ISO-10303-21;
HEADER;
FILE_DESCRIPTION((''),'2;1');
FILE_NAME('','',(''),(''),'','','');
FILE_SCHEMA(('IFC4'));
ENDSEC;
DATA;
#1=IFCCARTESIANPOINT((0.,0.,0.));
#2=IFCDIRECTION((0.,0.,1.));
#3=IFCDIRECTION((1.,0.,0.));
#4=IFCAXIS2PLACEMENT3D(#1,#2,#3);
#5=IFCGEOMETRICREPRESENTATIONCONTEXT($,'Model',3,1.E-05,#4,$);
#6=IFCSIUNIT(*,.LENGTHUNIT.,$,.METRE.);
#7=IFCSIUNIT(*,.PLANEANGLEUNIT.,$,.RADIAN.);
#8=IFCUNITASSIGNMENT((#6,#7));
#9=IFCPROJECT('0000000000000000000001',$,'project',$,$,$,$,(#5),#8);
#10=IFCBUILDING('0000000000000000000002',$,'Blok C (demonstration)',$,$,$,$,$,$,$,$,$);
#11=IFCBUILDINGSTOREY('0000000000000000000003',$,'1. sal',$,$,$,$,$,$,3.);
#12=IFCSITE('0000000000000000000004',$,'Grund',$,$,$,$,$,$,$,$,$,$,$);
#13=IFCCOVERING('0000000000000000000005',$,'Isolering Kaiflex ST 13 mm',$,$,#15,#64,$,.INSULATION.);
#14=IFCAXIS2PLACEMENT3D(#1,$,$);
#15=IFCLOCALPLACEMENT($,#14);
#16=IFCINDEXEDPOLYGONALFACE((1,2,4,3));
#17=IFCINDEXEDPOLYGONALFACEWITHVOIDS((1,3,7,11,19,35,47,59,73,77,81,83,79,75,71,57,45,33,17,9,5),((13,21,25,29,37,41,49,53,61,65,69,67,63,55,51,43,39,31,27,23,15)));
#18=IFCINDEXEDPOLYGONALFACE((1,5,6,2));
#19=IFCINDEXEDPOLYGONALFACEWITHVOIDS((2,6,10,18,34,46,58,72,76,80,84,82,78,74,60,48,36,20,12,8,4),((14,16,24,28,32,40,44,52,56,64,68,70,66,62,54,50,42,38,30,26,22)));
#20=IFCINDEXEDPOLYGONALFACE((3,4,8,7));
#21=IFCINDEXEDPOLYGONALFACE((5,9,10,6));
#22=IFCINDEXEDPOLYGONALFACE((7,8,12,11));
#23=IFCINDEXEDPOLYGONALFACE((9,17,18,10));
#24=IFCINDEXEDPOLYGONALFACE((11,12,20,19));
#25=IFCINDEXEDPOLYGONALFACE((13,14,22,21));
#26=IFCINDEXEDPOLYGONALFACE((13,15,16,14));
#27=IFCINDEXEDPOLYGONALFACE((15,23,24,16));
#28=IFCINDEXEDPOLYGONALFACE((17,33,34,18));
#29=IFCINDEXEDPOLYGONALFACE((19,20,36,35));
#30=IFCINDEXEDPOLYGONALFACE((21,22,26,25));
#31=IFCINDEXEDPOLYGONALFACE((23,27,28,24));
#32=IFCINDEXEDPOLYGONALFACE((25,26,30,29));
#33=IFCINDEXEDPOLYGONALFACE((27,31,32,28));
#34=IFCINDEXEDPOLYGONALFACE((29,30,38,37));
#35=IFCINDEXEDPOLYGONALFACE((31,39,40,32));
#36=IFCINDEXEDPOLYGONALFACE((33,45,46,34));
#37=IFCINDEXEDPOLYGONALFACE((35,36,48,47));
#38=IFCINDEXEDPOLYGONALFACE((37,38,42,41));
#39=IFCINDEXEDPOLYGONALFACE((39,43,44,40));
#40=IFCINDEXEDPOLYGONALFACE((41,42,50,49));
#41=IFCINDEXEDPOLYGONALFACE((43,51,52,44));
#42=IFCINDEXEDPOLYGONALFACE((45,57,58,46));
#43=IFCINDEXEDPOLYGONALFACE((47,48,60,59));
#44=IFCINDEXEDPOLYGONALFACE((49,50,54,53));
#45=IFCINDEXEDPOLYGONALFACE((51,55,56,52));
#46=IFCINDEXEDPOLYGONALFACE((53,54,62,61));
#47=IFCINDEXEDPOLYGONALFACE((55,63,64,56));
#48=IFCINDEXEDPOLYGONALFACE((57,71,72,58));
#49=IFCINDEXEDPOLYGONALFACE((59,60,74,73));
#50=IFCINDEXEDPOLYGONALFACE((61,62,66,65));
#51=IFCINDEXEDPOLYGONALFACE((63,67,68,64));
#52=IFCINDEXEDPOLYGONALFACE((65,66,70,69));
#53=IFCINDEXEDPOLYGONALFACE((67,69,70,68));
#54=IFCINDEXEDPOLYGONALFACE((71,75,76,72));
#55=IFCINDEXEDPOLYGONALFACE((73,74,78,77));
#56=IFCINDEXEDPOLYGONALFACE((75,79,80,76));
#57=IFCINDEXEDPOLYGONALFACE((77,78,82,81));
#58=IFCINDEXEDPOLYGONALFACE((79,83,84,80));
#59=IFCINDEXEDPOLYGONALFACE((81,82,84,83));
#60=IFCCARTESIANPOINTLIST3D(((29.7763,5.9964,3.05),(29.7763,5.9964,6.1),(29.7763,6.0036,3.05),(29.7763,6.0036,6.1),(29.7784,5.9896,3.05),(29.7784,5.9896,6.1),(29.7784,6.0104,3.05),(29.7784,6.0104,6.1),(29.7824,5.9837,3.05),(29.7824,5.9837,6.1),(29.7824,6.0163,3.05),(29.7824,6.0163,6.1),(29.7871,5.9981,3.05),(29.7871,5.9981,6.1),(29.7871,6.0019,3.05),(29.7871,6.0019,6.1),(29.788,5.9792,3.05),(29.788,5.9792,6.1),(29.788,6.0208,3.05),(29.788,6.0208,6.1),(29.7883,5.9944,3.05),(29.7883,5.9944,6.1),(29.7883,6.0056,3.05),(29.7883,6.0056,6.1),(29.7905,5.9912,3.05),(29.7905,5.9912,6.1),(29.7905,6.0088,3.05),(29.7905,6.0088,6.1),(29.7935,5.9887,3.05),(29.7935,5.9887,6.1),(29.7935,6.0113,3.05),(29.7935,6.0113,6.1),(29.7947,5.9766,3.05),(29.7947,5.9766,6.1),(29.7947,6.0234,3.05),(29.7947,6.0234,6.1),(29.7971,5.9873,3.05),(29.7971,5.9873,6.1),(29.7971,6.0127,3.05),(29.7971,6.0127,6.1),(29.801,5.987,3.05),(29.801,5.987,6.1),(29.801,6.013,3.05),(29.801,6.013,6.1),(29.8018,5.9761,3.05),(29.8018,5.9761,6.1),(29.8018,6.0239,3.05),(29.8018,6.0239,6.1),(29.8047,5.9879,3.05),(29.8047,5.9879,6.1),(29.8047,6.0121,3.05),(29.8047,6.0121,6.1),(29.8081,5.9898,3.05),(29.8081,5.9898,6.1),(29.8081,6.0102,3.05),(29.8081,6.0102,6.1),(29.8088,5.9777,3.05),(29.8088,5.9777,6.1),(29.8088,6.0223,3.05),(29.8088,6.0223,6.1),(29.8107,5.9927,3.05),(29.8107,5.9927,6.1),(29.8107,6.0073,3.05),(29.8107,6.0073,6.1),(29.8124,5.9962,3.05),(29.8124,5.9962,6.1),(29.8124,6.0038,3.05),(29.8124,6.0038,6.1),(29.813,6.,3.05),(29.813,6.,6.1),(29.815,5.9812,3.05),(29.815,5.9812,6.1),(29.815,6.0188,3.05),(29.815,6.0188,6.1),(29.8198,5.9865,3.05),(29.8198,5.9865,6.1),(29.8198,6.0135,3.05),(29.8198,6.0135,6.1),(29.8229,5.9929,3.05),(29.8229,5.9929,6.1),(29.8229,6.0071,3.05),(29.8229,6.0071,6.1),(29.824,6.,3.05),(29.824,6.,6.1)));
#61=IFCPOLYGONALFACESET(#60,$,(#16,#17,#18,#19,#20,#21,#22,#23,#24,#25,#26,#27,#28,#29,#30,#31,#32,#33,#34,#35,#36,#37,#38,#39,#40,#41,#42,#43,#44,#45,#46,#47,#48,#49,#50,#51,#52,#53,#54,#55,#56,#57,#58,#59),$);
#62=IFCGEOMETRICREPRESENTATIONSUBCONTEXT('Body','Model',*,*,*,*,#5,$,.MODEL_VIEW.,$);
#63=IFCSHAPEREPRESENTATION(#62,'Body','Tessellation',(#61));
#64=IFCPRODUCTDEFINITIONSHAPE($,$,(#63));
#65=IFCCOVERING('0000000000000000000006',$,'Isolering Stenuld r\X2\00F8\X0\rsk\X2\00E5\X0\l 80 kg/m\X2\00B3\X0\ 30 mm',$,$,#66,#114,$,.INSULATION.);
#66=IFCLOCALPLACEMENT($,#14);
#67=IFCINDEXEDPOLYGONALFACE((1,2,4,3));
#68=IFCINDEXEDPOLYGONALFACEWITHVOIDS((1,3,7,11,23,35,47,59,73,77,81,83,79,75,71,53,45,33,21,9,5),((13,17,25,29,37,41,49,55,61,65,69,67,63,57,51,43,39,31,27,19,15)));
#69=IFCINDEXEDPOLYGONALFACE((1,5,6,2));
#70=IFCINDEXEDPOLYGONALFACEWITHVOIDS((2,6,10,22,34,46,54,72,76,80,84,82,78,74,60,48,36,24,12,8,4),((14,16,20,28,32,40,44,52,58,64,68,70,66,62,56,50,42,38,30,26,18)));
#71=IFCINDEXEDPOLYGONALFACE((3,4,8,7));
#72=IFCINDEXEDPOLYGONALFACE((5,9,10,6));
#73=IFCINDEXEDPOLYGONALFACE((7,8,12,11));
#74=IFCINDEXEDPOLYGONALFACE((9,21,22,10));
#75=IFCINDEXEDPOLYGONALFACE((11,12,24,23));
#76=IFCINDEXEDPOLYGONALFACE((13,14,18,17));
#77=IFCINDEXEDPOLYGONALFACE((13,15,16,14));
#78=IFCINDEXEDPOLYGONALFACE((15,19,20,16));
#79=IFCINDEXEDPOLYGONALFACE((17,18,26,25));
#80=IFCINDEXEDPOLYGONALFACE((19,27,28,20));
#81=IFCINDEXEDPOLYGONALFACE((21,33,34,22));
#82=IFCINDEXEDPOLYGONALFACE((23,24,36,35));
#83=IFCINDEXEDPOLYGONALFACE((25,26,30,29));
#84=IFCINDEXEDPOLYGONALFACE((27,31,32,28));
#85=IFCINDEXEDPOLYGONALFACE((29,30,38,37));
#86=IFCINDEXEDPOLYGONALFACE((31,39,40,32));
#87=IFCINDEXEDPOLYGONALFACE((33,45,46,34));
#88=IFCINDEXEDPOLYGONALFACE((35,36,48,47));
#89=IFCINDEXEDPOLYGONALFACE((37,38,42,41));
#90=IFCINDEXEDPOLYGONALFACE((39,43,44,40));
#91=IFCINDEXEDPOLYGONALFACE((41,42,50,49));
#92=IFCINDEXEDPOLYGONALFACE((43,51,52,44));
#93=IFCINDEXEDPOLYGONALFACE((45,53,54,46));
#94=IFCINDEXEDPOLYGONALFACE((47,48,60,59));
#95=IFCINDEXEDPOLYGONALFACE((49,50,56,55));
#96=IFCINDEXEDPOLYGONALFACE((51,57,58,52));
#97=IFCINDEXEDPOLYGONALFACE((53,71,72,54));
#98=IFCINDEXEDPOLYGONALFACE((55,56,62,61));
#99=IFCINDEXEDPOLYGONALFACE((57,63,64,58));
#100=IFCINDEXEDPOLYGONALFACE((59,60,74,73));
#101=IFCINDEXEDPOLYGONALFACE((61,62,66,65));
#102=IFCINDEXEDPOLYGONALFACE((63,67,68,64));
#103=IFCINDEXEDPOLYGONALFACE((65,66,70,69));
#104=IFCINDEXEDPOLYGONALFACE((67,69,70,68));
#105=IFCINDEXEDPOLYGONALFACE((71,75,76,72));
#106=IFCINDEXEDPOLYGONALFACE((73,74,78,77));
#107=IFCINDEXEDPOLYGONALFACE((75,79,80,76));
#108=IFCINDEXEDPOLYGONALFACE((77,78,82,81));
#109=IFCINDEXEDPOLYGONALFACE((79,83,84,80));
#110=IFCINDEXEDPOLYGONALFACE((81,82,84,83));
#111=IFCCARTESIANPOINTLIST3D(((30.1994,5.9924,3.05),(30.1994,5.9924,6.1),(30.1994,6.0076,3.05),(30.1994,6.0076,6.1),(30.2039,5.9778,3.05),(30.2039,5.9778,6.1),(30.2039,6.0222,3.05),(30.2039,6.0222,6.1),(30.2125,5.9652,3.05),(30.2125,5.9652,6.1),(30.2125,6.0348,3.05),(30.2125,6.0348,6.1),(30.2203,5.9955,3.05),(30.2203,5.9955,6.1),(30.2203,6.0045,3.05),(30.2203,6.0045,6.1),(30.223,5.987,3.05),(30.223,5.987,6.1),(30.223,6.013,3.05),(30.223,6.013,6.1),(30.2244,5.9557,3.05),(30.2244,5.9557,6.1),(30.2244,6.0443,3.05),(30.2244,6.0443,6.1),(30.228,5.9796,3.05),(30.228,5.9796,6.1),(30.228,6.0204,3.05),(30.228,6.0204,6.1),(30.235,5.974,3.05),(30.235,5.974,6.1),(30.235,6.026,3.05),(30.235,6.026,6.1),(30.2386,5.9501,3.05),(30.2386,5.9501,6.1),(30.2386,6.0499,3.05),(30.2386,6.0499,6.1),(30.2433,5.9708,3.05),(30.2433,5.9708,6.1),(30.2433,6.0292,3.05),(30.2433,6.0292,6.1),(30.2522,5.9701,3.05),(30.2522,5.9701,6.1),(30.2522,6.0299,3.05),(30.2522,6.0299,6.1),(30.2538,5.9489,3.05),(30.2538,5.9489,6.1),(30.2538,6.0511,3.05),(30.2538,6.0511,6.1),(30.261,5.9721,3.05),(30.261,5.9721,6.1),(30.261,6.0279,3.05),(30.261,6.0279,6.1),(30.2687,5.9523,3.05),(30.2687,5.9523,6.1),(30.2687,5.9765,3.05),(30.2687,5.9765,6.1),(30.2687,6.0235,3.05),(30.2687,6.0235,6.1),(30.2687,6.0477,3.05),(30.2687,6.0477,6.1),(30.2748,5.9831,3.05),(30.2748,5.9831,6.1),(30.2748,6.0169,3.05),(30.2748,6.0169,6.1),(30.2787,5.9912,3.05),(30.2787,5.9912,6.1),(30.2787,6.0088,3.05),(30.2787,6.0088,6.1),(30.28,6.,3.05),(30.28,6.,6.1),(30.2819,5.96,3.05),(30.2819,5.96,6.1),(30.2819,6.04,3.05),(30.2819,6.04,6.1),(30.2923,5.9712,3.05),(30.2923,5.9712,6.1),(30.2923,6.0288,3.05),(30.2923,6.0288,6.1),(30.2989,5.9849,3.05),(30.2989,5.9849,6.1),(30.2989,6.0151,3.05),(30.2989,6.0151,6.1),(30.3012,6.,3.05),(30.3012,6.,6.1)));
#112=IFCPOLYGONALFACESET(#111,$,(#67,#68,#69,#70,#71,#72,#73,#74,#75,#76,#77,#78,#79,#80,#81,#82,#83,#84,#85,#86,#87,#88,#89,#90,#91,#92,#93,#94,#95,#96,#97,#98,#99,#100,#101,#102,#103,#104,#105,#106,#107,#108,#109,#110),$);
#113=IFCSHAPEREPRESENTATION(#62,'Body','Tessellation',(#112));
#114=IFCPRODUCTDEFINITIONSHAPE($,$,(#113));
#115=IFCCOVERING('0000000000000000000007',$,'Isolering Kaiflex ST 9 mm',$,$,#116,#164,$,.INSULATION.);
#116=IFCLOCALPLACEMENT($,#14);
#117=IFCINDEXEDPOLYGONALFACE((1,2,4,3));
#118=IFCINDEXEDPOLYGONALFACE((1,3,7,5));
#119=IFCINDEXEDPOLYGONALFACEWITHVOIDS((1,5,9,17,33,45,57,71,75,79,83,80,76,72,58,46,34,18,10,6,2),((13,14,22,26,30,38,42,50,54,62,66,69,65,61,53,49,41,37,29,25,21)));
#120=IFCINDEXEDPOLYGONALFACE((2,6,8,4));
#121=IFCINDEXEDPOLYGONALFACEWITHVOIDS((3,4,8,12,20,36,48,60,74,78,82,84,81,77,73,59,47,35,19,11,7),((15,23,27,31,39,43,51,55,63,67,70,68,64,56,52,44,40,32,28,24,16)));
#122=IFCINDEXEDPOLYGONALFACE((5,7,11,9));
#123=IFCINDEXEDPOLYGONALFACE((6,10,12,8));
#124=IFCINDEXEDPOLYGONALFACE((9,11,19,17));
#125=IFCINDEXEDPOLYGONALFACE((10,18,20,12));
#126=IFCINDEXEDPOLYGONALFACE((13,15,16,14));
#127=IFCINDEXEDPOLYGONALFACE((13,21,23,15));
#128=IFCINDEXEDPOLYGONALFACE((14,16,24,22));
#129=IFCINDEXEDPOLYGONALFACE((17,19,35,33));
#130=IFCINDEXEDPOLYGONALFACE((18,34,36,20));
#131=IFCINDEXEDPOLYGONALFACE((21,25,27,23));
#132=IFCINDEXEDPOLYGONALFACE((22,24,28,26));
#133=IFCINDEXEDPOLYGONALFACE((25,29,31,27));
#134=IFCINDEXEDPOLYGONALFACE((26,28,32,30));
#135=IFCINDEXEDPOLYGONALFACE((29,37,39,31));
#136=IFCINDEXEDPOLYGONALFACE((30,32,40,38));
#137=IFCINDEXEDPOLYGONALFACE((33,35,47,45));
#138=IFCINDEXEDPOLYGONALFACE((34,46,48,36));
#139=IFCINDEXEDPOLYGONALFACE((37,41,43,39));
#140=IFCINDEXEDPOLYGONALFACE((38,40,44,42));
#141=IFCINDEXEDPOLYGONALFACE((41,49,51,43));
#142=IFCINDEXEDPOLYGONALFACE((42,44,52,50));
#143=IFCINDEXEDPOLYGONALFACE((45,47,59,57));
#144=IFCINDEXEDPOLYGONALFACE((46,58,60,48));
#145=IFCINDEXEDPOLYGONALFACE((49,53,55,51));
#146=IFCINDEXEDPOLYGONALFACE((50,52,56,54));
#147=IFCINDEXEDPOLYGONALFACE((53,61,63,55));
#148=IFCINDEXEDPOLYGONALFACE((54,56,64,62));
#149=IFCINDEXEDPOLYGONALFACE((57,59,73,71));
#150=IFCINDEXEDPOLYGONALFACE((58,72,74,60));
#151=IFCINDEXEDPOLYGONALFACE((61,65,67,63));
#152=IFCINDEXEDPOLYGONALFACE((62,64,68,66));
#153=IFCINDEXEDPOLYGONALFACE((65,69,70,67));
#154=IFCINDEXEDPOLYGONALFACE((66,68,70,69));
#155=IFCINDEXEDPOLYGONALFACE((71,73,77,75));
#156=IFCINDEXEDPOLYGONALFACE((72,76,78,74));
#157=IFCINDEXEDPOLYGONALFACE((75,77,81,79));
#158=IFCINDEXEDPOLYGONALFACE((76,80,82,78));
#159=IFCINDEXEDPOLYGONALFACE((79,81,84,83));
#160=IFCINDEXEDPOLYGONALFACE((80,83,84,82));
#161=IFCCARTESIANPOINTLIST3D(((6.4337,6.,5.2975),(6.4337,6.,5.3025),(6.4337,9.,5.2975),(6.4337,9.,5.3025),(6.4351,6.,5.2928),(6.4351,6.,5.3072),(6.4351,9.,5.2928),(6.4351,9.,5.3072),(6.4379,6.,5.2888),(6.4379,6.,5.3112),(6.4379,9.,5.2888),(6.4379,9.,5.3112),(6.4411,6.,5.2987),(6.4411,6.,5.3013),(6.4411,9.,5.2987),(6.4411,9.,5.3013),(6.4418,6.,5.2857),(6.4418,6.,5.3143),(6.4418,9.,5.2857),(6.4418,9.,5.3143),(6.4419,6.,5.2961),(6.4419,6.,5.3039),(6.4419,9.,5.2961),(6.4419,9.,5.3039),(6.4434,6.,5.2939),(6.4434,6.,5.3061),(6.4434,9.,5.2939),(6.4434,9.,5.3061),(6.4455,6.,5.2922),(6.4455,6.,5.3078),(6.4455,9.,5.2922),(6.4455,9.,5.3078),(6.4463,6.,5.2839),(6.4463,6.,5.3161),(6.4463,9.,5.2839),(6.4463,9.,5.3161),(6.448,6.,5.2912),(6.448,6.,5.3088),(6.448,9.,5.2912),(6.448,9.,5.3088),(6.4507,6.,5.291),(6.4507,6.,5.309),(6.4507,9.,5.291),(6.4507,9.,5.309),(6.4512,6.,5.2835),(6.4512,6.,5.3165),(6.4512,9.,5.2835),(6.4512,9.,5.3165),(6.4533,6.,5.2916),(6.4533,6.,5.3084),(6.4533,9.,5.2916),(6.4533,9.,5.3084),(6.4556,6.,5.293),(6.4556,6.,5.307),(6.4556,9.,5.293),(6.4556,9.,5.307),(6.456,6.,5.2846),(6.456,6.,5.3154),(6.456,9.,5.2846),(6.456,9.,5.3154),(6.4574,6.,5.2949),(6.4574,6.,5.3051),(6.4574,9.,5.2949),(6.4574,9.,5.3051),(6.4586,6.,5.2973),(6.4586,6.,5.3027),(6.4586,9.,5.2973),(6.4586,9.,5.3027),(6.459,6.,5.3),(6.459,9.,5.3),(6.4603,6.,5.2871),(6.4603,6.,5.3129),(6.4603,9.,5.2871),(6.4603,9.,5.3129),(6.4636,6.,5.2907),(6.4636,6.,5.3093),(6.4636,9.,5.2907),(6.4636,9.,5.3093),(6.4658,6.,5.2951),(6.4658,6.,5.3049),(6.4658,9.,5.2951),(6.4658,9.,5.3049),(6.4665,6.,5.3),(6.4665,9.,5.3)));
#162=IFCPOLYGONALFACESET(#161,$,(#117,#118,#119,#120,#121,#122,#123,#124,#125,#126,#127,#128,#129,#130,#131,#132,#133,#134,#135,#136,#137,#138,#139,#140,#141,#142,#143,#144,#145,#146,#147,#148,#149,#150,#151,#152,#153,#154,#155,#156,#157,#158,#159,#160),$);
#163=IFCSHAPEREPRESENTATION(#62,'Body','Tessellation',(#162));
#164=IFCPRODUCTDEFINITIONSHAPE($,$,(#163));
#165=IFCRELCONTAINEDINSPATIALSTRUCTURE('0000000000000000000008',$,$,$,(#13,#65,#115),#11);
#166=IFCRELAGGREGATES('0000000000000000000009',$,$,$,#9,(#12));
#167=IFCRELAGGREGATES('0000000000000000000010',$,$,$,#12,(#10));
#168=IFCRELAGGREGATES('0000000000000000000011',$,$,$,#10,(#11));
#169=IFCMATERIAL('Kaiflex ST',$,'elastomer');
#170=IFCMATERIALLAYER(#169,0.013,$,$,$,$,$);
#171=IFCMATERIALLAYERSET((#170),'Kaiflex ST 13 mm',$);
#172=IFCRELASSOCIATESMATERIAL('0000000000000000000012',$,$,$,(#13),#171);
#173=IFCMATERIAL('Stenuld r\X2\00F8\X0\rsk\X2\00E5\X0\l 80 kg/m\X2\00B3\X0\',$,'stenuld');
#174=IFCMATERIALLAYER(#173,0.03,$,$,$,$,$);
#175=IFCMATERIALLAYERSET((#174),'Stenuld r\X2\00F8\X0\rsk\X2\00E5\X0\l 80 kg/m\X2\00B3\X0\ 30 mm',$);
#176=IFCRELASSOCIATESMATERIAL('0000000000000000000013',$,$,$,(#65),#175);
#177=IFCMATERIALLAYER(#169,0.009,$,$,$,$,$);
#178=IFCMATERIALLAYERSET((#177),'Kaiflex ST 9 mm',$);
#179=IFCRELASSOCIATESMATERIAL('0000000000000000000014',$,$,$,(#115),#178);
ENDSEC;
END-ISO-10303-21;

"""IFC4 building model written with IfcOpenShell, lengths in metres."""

from ifc_helpers import new_model, si_unit, frame, origin_with_axes, place, context, subcontext, project, spatial, hollow_circle, extrude, material, layer, layer_set, element, save


model = new_model("IFC4")

# Units and contexts
model_context = context("Model", 3, precision=1e-05, world=origin_with_axes())
body_context = subcontext(model_context, "Body", "Model", "MODEL_VIEW")
ifc_project = project(units=[si_unit("LENGTHUNIT", "METRE"), si_unit("PLANEANGLEUNIT", "RADIAN")], contexts=[model_context])

# Site, building, storey
site = spatial("IfcSite", under=ifc_project, Name="Grund")
building = spatial("IfcBuilding", under=site, Name="Blok C (demonstration)")
storey = spatial("IfcBuildingStorey", under=building, Name="1. sal", Elevation=3.0)

# Coverings
ifc_material_1 = material(Name="Stenuld rørskål 80 kg/m³", Category="stenuld")
ifc_material_2 = material(Name="Kaiflex ST", Category="elastomer")
ifc_layer_1 = layer(ifc_material_2, 0.013)
ifc_layer_set_1 = layer_set([ifc_layer_1], Name="Kaiflex ST 13 mm")
covering_1_placement = place(None, origin_with_axes())
element("IfcCovering", 1, at=covering_1_placement, inside=storey, material=ifc_layer_set_1, Name="Isolering Kaiflex ST 13 mm", PredefinedType="INSULATION", context=body_context, shape_type="SweptSolid", body=[
    extrude(hollow_circle(Radius=0.024, WallThickness=0.011), frame((29.8, 6.0, 3.05), z_axis=(0.0, 0.0, 1.0), x_axis=(1.0, 0.0, 0.0)), (0.0, 0.0, 1.0), 3.05),
])
ifc_layer_2 = layer(ifc_material_1, 0.03)
ifc_layer_set_2 = layer_set([ifc_layer_2], Name="Stenuld rørskål 80 kg/m³ 30 mm")
covering_2_placement = place(None, origin_with_axes())
element("IfcCovering", 2, at=covering_2_placement, inside=storey, material=ifc_layer_set_2, Name="Isolering Stenuld rørskål 80 kg/m³ 30 mm", PredefinedType="INSULATION", context=body_context, shape_type="SweptSolid", body=[
    extrude(hollow_circle(Radius=0.0512, WallThickness=0.0212), frame((30.25, 6.0, 3.05), z_axis=(0.0, 0.0, 1.0), x_axis=(1.0, 0.0, 0.0)), (0.0, 0.0, 1.0), 3.05),
])
ifc_layer_3 = layer(ifc_material_2, 0.009)
ifc_layer_set_3 = layer_set([ifc_layer_3], Name="Kaiflex ST 9 mm")
covering_3_placement = place(None, origin_with_axes())
element("IfcCovering", 3, at=covering_3_placement, inside=storey, material=ifc_layer_set_3, Name="Isolering Kaiflex ST 9 mm", PredefinedType="INSULATION", context=body_context, shape_type="SweptSolid", body=[
    extrude(hollow_circle(Radius=0.0165, WallThickness=0.0075), frame((6.45, 6.0, 5.3), z_axis=(0.0, 1.0, 0.0), x_axis=(1.0, 0.0, 0.0)), (0.0, 0.0, 1.0), 3.0),
])

save(model, "model.ifc")
